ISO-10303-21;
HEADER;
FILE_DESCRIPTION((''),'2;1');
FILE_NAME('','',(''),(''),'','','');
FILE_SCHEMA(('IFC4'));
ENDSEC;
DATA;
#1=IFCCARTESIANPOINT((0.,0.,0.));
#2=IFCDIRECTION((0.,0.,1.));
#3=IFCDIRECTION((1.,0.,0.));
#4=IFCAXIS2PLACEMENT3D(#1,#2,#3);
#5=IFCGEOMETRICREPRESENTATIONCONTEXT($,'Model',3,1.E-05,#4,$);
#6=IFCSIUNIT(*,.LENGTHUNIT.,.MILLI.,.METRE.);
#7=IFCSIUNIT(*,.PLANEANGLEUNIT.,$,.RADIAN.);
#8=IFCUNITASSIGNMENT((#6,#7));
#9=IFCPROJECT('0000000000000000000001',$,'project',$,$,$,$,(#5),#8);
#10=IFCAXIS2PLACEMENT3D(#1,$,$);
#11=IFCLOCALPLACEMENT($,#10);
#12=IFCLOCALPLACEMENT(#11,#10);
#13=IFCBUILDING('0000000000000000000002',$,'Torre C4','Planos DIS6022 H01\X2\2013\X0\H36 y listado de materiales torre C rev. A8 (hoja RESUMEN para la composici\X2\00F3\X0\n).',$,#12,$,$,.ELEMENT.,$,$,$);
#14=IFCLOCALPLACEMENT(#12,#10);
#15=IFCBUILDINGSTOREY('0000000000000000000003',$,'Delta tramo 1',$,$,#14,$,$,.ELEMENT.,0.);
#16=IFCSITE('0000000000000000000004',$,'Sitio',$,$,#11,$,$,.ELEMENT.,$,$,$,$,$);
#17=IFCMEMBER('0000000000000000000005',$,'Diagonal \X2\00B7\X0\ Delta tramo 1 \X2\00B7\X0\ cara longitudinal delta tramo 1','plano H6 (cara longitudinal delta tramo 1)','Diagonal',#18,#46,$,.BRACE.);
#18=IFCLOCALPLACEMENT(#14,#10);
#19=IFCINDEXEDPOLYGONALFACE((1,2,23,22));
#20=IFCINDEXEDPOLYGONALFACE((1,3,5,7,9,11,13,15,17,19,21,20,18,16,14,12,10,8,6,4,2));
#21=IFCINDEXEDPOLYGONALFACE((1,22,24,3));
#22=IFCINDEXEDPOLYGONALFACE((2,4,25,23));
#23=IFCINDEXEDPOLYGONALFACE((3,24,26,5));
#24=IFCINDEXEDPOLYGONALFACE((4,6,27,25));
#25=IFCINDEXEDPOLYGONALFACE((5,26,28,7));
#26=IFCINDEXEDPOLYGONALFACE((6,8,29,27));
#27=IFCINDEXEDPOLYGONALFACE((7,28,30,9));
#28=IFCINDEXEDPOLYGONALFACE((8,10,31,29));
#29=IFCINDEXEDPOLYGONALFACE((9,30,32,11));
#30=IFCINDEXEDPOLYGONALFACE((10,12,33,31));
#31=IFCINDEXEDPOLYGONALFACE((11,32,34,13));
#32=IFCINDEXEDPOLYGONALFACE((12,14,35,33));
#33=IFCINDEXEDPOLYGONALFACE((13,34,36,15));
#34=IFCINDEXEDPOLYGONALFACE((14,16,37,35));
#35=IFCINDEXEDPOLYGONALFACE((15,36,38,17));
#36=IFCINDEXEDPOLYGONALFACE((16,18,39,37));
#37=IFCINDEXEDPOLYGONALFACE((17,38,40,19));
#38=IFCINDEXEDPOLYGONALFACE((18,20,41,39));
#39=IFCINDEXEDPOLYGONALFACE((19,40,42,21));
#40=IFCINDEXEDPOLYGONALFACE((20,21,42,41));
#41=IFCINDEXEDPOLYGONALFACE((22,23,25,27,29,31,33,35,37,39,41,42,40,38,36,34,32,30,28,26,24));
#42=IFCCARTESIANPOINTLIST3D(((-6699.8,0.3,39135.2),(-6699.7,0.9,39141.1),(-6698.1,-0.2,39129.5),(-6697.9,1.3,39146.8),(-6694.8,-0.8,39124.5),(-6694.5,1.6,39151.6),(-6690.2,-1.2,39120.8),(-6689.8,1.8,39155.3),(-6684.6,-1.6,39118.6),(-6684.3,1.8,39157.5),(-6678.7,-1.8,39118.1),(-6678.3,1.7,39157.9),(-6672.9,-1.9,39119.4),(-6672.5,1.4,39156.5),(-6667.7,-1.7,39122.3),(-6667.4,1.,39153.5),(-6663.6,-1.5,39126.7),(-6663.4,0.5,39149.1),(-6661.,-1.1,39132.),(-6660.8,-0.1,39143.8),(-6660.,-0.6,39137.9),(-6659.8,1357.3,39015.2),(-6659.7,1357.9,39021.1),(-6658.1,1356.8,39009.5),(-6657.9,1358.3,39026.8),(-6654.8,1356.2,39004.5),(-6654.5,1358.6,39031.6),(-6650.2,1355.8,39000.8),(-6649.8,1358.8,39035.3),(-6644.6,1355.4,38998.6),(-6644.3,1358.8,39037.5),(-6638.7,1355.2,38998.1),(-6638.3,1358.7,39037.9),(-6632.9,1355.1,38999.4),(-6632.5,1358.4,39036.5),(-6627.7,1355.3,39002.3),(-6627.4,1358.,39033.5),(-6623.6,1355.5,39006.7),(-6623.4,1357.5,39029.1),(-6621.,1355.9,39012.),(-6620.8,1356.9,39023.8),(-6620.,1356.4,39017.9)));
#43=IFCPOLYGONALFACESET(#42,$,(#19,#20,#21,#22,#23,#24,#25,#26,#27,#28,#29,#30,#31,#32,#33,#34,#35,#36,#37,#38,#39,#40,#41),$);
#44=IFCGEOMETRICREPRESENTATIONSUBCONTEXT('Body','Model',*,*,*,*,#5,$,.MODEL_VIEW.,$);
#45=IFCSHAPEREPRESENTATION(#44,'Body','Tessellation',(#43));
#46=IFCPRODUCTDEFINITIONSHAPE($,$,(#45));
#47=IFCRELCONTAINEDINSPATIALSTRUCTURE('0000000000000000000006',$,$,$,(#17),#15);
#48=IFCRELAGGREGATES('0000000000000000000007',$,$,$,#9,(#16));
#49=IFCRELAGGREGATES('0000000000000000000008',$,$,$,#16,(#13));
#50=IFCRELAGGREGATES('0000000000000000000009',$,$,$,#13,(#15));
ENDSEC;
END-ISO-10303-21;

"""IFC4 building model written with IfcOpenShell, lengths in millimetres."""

from ifc_helpers import new_model, si_unit, frame, origin, origin_with_axes, place, context, subcontext, project, spatial, circle, extrude, element, save


model = new_model("IFC4")

# Units and contexts
model_context = context("Model", 3, precision=1e-05, world=origin_with_axes())
body_context = subcontext(model_context, "Body", "Model", "MODEL_VIEW")
ifc_project = project(units=[si_unit("LENGTHUNIT", "METRE", prefix="MILLI"), si_unit("PLANEANGLEUNIT", "RADIAN")], contexts=[model_context])

# Site, building, storey
site_placement = place(None, origin())
site = spatial("IfcSite", under=ifc_project, at=site_placement, Name="Sitio", CompositionType="ELEMENT")
building_placement = place(site_placement, origin())
building = spatial("IfcBuilding", under=site, at=building_placement, Name="Torre C4", Description="Planos DIS6022 H01–H36 y listado de materiales torre C rev. A8 (hoja RESUMEN para la composición).", CompositionType="ELEMENT")
storey_placement = place(building_placement, origin())
storey = spatial("IfcBuildingStorey", under=building, at=storey_placement, Name="Delta tramo 1", CompositionType="ELEMENT", Elevation=0.0)

# Member
for number, where, z_axis, x_axis, name in (
    (1, (-6680.0, 0.0, 39138.0), (0.02935, 0.995684, -0.088049), (0.999529, -0.030023, -0.006331), "Diagonal · Delta tramo 1 · cara longitudinal delta tramo 1"),
):
    element("IfcMember", number, at=place(storey_placement, frame(where, z_axis=z_axis, x_axis=x_axis)), inside=storey, Name=name, Description="plano H6 (cara longitudinal delta tramo 1)", ObjectType="Diagonal", PredefinedType="BRACE", context=body_context, shape_type="SweptSolid", body=[
        extrude(circle(Radius=20.0), None, (0.0, 0.0, 1.0), 1362.9),
    ])

save(model, "model.ifc")
